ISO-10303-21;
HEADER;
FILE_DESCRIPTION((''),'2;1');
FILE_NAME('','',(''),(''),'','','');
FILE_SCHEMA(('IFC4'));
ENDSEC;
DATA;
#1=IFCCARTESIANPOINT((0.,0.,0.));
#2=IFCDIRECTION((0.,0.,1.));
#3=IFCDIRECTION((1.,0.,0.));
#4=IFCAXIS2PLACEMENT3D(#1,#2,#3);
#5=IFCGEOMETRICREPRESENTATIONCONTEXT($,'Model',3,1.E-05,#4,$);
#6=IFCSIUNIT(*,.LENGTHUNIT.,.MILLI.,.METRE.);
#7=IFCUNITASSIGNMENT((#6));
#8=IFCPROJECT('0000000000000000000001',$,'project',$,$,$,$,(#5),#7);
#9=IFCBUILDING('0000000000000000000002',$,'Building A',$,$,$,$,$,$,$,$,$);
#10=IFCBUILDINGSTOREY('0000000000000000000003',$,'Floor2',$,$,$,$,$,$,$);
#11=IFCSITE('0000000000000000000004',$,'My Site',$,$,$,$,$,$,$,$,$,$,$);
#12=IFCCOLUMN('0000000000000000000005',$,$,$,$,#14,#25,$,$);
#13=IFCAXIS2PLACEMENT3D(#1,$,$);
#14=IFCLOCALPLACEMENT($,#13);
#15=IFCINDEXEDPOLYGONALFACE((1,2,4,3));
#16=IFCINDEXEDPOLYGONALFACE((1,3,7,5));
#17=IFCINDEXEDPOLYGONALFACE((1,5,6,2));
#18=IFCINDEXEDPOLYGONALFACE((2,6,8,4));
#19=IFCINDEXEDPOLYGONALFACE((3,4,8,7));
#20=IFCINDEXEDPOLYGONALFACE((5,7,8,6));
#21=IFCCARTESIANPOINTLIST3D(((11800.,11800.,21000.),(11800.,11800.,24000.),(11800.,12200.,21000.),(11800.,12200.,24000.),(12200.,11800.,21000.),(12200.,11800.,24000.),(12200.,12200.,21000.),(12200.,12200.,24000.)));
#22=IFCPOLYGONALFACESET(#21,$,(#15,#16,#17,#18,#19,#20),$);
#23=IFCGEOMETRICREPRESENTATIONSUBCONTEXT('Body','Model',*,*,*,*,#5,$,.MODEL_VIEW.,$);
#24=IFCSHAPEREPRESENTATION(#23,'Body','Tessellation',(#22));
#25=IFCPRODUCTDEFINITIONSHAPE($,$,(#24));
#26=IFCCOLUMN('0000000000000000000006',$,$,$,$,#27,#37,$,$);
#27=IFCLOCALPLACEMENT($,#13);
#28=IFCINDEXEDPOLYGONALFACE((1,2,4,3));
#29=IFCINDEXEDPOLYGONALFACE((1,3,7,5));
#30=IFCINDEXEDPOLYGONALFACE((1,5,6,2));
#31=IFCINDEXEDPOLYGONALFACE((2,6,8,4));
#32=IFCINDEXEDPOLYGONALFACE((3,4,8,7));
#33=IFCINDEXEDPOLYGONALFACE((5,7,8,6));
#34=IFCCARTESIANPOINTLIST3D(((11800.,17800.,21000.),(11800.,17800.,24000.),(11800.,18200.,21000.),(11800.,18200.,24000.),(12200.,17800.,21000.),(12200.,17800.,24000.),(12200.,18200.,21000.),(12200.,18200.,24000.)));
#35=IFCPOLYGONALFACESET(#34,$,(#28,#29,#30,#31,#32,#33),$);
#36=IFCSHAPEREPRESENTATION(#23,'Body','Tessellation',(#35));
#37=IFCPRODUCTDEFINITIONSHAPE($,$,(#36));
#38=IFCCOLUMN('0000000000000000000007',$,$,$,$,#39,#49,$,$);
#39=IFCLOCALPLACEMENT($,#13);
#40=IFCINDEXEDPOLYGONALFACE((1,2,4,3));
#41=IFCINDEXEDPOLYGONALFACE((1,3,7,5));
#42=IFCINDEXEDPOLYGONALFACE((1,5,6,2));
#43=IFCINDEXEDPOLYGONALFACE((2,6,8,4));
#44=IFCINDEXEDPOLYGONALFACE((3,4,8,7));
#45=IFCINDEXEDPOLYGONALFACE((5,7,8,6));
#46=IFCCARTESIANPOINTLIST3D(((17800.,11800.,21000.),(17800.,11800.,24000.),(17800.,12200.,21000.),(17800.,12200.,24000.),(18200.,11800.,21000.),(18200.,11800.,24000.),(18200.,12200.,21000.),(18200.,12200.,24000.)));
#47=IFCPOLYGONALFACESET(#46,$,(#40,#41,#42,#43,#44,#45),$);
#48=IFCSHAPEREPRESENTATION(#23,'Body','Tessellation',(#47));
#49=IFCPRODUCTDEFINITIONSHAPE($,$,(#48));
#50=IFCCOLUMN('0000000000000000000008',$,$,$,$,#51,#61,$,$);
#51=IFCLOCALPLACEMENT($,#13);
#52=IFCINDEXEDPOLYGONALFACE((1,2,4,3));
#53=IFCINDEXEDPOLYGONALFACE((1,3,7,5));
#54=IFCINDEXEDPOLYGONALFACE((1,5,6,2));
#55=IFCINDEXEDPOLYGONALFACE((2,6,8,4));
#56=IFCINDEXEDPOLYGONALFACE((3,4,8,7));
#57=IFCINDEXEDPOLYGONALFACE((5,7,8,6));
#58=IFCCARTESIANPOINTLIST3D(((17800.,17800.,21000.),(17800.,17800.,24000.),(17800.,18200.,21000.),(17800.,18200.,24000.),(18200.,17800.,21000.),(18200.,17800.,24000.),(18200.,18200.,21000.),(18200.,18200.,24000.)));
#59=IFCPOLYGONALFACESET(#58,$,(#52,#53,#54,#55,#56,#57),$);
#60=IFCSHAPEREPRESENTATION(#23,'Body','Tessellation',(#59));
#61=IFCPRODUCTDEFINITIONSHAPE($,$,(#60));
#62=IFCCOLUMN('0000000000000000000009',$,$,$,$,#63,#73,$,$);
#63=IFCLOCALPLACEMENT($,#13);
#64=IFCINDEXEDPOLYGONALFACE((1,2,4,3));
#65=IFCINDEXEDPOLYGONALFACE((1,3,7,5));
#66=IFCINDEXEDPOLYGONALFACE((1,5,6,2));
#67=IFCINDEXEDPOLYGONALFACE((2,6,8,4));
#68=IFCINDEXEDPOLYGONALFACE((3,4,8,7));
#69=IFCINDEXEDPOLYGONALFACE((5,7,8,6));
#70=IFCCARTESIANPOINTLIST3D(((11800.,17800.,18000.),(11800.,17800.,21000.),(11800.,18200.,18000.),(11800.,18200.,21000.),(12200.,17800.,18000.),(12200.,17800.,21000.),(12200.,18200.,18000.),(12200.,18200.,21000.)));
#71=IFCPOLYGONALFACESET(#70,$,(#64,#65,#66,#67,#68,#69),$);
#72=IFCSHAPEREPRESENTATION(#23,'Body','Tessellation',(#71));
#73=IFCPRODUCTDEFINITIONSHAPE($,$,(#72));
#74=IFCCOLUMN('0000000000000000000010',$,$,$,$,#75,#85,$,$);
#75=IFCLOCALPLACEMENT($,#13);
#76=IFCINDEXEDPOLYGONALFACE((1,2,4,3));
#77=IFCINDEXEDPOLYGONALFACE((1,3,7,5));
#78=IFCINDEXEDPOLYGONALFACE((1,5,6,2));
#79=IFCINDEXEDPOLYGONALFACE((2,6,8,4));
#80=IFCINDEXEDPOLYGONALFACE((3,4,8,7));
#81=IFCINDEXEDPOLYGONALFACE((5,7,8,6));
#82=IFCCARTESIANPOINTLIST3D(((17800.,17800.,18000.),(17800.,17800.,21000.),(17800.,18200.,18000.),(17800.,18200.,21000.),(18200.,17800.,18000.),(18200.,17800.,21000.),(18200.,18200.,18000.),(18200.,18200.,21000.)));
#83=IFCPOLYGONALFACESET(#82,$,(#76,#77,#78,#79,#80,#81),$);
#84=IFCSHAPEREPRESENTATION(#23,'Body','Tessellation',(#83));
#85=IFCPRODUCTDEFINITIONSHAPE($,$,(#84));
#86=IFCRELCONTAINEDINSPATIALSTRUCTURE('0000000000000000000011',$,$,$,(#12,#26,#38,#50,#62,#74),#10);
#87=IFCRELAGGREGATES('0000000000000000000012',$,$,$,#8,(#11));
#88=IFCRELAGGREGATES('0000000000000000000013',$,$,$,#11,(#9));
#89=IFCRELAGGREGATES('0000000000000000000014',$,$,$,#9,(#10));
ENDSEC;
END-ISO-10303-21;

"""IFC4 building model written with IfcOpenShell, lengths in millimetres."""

from ifc_helpers import new_model, si_unit, frame, origin_with_axes, place, context, subcontext, project, spatial, line, indexed_curve, outline, extrude, element, save


model = new_model("IFC4")

# Units and contexts
model_context = context("Model", 3, precision=1e-05, world=origin_with_axes())
body_context = subcontext(model_context, "Body", "Model", "MODEL_VIEW")
ifc_project = project(units=[si_unit("LENGTHUNIT", "METRE", prefix="MILLI")], contexts=[model_context])

# Site, building, storey
site = spatial("IfcSite", under=ifc_project, Name="My Site")
building = spatial("IfcBuilding", under=site, Name="Building A")
storey = spatial("IfcBuildingStorey", under=building, Name="Floor2")

# Columns
for number, where, z_axis, x_axis in (
    (1, (12000.0, 12000.0, 21000.0), (0.0, 0.0, 1.0), (1.0, 0.0, 0.0)),
    (2, (12000.0, 18000.0, 21000.0), (0.0, 0.0, 1.0), (1.0, 0.0, 0.0)),
    (3, (18000.0, 12000.0, 21000.0), (0.0, 0.0, 1.0), (1.0, 0.0, 0.0)),
    (4, (18000.0, 18000.0, 21000.0), (0.0, 0.0, 1.0), (1.0, 0.0, 0.0)),
    (5, (12000.0, 18000.0, 18000.0), (0.0, 0.0, 1.0), (1.0, 0.0, 0.0)),
    (6, (18000.0, 18000.0, 18000.0), (0.0, 0.0, 1.0), (1.0, 0.0, 0.0)),
):
    element("IfcColumn", number, at=place(None, frame(where, z_axis=z_axis, x_axis=x_axis)), inside=storey, context=body_context, shape_type="SweptSolid", body=[
        extrude(outline(indexed_curve([(-200.0, -200.0), (200.0, -200.0), (200.0, 200.0), (-200.0, 200.0)], segments=[line(1, 2, 3, 4, 1)])), origin_with_axes(), (0.0, 0.0, 1.0), 3000.0),
    ])

save(model, "model.ifc")
